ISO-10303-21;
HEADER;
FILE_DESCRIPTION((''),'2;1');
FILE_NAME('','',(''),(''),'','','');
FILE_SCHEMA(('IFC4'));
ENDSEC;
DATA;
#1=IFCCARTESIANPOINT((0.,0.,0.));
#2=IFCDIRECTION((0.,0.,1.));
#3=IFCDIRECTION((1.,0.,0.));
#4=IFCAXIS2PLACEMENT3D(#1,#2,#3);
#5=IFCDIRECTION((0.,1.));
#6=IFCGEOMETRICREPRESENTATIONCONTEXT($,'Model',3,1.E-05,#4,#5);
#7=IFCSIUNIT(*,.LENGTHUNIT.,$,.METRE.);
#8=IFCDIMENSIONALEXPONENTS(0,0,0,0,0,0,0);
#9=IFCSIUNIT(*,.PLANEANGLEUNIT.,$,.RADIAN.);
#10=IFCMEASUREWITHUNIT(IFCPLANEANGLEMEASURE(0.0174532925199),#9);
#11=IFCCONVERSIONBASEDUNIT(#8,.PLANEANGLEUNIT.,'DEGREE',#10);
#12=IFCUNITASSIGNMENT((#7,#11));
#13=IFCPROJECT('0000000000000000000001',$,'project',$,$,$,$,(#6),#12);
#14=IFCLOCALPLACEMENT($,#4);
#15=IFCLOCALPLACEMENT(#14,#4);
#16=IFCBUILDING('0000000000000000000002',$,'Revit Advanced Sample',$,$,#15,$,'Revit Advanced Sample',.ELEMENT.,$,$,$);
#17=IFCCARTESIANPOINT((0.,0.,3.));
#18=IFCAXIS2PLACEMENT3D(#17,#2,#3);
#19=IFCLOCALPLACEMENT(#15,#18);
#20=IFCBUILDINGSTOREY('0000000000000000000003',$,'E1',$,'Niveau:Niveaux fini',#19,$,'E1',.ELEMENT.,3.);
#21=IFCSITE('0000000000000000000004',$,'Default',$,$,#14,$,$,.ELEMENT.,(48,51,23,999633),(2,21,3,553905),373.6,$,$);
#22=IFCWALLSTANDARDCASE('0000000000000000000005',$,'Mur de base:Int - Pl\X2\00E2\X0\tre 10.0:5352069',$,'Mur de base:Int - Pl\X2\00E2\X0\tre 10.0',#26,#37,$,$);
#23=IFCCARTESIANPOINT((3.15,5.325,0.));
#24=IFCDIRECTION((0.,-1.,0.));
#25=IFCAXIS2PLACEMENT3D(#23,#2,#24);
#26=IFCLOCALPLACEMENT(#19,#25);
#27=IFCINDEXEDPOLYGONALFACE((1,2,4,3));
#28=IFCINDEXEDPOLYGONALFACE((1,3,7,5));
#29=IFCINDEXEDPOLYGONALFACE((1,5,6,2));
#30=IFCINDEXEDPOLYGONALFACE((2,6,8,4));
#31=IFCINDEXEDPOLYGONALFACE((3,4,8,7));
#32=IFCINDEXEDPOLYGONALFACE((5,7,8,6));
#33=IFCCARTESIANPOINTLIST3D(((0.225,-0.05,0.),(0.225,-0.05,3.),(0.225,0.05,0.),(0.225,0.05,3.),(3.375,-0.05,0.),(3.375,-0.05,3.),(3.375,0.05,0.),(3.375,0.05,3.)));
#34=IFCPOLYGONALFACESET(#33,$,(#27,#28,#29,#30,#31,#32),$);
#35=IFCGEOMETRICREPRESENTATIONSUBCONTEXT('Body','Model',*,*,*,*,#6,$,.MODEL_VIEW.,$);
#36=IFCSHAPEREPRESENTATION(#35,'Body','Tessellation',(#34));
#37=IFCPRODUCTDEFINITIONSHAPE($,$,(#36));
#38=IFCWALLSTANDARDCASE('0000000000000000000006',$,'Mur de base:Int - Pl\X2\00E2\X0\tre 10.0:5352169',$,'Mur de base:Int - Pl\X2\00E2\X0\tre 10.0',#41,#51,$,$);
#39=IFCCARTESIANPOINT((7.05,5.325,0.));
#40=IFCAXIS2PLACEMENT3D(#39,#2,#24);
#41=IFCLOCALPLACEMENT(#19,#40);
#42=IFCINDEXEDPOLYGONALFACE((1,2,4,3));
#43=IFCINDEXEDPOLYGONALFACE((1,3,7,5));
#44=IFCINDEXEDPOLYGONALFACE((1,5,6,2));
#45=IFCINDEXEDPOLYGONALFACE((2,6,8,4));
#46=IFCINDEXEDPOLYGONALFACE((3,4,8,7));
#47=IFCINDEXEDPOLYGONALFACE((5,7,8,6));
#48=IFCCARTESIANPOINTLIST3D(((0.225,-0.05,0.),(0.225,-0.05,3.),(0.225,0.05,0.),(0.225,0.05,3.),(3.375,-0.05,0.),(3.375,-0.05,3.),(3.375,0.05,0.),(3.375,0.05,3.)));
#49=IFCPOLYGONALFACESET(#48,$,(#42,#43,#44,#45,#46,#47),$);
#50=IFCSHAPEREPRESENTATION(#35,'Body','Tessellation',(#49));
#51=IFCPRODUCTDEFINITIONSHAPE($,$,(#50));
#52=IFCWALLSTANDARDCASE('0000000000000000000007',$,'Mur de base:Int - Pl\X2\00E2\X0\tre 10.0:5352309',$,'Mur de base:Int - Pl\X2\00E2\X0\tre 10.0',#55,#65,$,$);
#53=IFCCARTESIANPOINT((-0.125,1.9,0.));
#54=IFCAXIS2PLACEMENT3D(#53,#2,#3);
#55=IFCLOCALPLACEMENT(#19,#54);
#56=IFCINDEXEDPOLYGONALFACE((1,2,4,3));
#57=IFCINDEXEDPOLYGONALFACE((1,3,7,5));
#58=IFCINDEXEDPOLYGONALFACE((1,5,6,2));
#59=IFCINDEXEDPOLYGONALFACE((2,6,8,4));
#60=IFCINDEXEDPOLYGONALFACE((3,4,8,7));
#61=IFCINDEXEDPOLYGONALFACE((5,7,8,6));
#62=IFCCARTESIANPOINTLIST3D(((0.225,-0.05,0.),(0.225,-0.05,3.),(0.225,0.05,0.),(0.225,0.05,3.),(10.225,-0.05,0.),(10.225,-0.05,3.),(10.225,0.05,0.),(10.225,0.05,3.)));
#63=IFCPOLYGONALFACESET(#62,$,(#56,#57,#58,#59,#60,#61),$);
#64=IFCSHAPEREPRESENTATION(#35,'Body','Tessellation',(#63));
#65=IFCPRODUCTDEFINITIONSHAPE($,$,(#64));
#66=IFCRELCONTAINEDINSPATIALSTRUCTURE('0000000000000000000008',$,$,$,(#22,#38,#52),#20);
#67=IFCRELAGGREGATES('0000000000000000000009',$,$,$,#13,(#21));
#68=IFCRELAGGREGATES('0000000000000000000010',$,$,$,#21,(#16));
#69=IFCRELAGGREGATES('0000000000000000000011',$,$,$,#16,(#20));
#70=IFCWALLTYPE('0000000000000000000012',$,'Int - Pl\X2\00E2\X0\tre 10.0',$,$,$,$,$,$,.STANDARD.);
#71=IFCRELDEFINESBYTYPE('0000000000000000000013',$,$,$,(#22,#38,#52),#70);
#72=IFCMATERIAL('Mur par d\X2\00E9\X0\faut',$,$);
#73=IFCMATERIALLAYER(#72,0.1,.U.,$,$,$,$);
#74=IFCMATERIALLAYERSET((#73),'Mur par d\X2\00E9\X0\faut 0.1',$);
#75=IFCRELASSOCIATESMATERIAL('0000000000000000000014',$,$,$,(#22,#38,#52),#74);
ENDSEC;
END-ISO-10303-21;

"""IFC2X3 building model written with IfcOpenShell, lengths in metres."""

from ifc_helpers import new_model, entity, si_unit, converted_unit, direction, frame, origin_with_axes, place, context, subcontext, project, spatial, polyline, outline, extrude, material, layer, layer_set, layer_usage, type_object, element, save


model = new_model("IFC2X3")

# Units and contexts
model_context = context("Model", 3, precision=1e-05, world=origin_with_axes(), true_north=direction((0.0, 1.0)))
body_context = subcontext(model_context, "Body", "Model", "MODEL_VIEW")
ifc_project = project(units=[si_unit("LENGTHUNIT", "METRE"), converted_unit("PLANEANGLEUNIT", "DEGREE", entity("IfcPlaneAngleMeasure", 0.0174532925199), si_unit("PLANEANGLEUNIT", "RADIAN"), dimensions=[0, 0, 0, 0, 0, 0, 0])], contexts=[model_context])

# Site, building, storey
site_placement = place(None, origin_with_axes())
site = spatial("IfcSite", under=ifc_project, at=site_placement, Name="Default", CompositionType="ELEMENT", RefLatitude=(48, 51, 23, 999633), RefLongitude=(2, 21, 3, 553905), RefElevation=373.6)
building_placement = place(site_placement, origin_with_axes())
building = spatial("IfcBuilding", under=site, at=building_placement, Name="Revit Advanced Sample", LongName="Revit Advanced Sample", CompositionType="ELEMENT")
storey_placement = place(building_placement, frame((0.0, 0.0, 3.0), z_axis=(0.0, 0.0, 1.0), x_axis=(1.0, 0.0, 0.0)))
storey = spatial("IfcBuildingStorey", under=building, at=storey_placement, Name="E1", ObjectType="Niveau:Niveaux fini", LongName="E1", CompositionType="ELEMENT", Elevation=3.0)

# Walls
ifc_material_1 = material(Name="Mur par défaut")
ifc_layer_1 = layer(ifc_material_1, 0.1, ventilated="UNKNOWN")
ifc_layer_set_1 = layer_set([ifc_layer_1], Name="Mur par défaut 0.1")
ifc_layer_usage_1 = layer_usage(ifc_layer_set_1, "AXIS2", "POSITIVE", -0.05)
wall_type_1 = type_object("IfcWallType", Name="Int - Plâtre 10.0", PredefinedType="STANDARD")
wall_1_placement = place(storey_placement, frame((3.15, 5.325, 0.0), z_axis=(0.0, 0.0, 1.0), x_axis=(0.0, -1.0, 0.0)))
element("IfcWallStandardCase", 1, at=wall_1_placement, inside=storey, type_object=wall_type_1, material=ifc_layer_usage_1, Name="Mur de base:Int - Plâtre 10.0:5352069", ObjectType="Mur de base:Int - Plâtre 10.0", context=body_context, shape_type="SweptSolid", body=[
    extrude(outline(polyline([(0.225, -0.05), (3.375, -0.05), (3.375, 0.05), (0.225, 0.05), (0.225, -0.05)])), origin_with_axes(), (0.0, 0.0, 1.0), 3.0),
])
ifc_layer_usage_2 = layer_usage(ifc_layer_set_1, "AXIS2", "POSITIVE", -0.05)
wall_2_placement = place(storey_placement, frame((7.05, 5.325, 0.0), z_axis=(0.0, 0.0, 1.0), x_axis=(0.0, -1.0, 0.0)))
element("IfcWallStandardCase", 2, at=wall_2_placement, inside=storey, type_object=wall_type_1, material=ifc_layer_usage_2, Name="Mur de base:Int - Plâtre 10.0:5352169", ObjectType="Mur de base:Int - Plâtre 10.0", context=body_context, shape_type="SweptSolid", body=[
    extrude(outline(polyline([(0.225, -0.05), (3.375, -0.05), (3.375, 0.05), (0.225, 0.05), (0.225, -0.05)])), origin_with_axes(), (0.0, 0.0, 1.0), 3.0),
])
ifc_layer_usage_3 = layer_usage(ifc_layer_set_1, "AXIS2", "POSITIVE", -0.05)
wall_3_placement = place(storey_placement, frame((-0.125, 1.9, 0.0), z_axis=(0.0, 0.0, 1.0), x_axis=(1.0, 0.0, 0.0)))
element("IfcWallStandardCase", 3, at=wall_3_placement, inside=storey, type_object=wall_type_1, material=ifc_layer_usage_3, Name="Mur de base:Int - Plâtre 10.0:5352309", ObjectType="Mur de base:Int - Plâtre 10.0", context=body_context, shape_type="SweptSolid", body=[
    extrude(outline(polyline([(0.225, -0.05), (10.225, -0.05), (10.225, 0.05), (0.225, 0.05), (0.225, -0.05)])), origin_with_axes(), (0.0, 0.0, 1.0), 3.0),
])

save(model, "model.ifc")
